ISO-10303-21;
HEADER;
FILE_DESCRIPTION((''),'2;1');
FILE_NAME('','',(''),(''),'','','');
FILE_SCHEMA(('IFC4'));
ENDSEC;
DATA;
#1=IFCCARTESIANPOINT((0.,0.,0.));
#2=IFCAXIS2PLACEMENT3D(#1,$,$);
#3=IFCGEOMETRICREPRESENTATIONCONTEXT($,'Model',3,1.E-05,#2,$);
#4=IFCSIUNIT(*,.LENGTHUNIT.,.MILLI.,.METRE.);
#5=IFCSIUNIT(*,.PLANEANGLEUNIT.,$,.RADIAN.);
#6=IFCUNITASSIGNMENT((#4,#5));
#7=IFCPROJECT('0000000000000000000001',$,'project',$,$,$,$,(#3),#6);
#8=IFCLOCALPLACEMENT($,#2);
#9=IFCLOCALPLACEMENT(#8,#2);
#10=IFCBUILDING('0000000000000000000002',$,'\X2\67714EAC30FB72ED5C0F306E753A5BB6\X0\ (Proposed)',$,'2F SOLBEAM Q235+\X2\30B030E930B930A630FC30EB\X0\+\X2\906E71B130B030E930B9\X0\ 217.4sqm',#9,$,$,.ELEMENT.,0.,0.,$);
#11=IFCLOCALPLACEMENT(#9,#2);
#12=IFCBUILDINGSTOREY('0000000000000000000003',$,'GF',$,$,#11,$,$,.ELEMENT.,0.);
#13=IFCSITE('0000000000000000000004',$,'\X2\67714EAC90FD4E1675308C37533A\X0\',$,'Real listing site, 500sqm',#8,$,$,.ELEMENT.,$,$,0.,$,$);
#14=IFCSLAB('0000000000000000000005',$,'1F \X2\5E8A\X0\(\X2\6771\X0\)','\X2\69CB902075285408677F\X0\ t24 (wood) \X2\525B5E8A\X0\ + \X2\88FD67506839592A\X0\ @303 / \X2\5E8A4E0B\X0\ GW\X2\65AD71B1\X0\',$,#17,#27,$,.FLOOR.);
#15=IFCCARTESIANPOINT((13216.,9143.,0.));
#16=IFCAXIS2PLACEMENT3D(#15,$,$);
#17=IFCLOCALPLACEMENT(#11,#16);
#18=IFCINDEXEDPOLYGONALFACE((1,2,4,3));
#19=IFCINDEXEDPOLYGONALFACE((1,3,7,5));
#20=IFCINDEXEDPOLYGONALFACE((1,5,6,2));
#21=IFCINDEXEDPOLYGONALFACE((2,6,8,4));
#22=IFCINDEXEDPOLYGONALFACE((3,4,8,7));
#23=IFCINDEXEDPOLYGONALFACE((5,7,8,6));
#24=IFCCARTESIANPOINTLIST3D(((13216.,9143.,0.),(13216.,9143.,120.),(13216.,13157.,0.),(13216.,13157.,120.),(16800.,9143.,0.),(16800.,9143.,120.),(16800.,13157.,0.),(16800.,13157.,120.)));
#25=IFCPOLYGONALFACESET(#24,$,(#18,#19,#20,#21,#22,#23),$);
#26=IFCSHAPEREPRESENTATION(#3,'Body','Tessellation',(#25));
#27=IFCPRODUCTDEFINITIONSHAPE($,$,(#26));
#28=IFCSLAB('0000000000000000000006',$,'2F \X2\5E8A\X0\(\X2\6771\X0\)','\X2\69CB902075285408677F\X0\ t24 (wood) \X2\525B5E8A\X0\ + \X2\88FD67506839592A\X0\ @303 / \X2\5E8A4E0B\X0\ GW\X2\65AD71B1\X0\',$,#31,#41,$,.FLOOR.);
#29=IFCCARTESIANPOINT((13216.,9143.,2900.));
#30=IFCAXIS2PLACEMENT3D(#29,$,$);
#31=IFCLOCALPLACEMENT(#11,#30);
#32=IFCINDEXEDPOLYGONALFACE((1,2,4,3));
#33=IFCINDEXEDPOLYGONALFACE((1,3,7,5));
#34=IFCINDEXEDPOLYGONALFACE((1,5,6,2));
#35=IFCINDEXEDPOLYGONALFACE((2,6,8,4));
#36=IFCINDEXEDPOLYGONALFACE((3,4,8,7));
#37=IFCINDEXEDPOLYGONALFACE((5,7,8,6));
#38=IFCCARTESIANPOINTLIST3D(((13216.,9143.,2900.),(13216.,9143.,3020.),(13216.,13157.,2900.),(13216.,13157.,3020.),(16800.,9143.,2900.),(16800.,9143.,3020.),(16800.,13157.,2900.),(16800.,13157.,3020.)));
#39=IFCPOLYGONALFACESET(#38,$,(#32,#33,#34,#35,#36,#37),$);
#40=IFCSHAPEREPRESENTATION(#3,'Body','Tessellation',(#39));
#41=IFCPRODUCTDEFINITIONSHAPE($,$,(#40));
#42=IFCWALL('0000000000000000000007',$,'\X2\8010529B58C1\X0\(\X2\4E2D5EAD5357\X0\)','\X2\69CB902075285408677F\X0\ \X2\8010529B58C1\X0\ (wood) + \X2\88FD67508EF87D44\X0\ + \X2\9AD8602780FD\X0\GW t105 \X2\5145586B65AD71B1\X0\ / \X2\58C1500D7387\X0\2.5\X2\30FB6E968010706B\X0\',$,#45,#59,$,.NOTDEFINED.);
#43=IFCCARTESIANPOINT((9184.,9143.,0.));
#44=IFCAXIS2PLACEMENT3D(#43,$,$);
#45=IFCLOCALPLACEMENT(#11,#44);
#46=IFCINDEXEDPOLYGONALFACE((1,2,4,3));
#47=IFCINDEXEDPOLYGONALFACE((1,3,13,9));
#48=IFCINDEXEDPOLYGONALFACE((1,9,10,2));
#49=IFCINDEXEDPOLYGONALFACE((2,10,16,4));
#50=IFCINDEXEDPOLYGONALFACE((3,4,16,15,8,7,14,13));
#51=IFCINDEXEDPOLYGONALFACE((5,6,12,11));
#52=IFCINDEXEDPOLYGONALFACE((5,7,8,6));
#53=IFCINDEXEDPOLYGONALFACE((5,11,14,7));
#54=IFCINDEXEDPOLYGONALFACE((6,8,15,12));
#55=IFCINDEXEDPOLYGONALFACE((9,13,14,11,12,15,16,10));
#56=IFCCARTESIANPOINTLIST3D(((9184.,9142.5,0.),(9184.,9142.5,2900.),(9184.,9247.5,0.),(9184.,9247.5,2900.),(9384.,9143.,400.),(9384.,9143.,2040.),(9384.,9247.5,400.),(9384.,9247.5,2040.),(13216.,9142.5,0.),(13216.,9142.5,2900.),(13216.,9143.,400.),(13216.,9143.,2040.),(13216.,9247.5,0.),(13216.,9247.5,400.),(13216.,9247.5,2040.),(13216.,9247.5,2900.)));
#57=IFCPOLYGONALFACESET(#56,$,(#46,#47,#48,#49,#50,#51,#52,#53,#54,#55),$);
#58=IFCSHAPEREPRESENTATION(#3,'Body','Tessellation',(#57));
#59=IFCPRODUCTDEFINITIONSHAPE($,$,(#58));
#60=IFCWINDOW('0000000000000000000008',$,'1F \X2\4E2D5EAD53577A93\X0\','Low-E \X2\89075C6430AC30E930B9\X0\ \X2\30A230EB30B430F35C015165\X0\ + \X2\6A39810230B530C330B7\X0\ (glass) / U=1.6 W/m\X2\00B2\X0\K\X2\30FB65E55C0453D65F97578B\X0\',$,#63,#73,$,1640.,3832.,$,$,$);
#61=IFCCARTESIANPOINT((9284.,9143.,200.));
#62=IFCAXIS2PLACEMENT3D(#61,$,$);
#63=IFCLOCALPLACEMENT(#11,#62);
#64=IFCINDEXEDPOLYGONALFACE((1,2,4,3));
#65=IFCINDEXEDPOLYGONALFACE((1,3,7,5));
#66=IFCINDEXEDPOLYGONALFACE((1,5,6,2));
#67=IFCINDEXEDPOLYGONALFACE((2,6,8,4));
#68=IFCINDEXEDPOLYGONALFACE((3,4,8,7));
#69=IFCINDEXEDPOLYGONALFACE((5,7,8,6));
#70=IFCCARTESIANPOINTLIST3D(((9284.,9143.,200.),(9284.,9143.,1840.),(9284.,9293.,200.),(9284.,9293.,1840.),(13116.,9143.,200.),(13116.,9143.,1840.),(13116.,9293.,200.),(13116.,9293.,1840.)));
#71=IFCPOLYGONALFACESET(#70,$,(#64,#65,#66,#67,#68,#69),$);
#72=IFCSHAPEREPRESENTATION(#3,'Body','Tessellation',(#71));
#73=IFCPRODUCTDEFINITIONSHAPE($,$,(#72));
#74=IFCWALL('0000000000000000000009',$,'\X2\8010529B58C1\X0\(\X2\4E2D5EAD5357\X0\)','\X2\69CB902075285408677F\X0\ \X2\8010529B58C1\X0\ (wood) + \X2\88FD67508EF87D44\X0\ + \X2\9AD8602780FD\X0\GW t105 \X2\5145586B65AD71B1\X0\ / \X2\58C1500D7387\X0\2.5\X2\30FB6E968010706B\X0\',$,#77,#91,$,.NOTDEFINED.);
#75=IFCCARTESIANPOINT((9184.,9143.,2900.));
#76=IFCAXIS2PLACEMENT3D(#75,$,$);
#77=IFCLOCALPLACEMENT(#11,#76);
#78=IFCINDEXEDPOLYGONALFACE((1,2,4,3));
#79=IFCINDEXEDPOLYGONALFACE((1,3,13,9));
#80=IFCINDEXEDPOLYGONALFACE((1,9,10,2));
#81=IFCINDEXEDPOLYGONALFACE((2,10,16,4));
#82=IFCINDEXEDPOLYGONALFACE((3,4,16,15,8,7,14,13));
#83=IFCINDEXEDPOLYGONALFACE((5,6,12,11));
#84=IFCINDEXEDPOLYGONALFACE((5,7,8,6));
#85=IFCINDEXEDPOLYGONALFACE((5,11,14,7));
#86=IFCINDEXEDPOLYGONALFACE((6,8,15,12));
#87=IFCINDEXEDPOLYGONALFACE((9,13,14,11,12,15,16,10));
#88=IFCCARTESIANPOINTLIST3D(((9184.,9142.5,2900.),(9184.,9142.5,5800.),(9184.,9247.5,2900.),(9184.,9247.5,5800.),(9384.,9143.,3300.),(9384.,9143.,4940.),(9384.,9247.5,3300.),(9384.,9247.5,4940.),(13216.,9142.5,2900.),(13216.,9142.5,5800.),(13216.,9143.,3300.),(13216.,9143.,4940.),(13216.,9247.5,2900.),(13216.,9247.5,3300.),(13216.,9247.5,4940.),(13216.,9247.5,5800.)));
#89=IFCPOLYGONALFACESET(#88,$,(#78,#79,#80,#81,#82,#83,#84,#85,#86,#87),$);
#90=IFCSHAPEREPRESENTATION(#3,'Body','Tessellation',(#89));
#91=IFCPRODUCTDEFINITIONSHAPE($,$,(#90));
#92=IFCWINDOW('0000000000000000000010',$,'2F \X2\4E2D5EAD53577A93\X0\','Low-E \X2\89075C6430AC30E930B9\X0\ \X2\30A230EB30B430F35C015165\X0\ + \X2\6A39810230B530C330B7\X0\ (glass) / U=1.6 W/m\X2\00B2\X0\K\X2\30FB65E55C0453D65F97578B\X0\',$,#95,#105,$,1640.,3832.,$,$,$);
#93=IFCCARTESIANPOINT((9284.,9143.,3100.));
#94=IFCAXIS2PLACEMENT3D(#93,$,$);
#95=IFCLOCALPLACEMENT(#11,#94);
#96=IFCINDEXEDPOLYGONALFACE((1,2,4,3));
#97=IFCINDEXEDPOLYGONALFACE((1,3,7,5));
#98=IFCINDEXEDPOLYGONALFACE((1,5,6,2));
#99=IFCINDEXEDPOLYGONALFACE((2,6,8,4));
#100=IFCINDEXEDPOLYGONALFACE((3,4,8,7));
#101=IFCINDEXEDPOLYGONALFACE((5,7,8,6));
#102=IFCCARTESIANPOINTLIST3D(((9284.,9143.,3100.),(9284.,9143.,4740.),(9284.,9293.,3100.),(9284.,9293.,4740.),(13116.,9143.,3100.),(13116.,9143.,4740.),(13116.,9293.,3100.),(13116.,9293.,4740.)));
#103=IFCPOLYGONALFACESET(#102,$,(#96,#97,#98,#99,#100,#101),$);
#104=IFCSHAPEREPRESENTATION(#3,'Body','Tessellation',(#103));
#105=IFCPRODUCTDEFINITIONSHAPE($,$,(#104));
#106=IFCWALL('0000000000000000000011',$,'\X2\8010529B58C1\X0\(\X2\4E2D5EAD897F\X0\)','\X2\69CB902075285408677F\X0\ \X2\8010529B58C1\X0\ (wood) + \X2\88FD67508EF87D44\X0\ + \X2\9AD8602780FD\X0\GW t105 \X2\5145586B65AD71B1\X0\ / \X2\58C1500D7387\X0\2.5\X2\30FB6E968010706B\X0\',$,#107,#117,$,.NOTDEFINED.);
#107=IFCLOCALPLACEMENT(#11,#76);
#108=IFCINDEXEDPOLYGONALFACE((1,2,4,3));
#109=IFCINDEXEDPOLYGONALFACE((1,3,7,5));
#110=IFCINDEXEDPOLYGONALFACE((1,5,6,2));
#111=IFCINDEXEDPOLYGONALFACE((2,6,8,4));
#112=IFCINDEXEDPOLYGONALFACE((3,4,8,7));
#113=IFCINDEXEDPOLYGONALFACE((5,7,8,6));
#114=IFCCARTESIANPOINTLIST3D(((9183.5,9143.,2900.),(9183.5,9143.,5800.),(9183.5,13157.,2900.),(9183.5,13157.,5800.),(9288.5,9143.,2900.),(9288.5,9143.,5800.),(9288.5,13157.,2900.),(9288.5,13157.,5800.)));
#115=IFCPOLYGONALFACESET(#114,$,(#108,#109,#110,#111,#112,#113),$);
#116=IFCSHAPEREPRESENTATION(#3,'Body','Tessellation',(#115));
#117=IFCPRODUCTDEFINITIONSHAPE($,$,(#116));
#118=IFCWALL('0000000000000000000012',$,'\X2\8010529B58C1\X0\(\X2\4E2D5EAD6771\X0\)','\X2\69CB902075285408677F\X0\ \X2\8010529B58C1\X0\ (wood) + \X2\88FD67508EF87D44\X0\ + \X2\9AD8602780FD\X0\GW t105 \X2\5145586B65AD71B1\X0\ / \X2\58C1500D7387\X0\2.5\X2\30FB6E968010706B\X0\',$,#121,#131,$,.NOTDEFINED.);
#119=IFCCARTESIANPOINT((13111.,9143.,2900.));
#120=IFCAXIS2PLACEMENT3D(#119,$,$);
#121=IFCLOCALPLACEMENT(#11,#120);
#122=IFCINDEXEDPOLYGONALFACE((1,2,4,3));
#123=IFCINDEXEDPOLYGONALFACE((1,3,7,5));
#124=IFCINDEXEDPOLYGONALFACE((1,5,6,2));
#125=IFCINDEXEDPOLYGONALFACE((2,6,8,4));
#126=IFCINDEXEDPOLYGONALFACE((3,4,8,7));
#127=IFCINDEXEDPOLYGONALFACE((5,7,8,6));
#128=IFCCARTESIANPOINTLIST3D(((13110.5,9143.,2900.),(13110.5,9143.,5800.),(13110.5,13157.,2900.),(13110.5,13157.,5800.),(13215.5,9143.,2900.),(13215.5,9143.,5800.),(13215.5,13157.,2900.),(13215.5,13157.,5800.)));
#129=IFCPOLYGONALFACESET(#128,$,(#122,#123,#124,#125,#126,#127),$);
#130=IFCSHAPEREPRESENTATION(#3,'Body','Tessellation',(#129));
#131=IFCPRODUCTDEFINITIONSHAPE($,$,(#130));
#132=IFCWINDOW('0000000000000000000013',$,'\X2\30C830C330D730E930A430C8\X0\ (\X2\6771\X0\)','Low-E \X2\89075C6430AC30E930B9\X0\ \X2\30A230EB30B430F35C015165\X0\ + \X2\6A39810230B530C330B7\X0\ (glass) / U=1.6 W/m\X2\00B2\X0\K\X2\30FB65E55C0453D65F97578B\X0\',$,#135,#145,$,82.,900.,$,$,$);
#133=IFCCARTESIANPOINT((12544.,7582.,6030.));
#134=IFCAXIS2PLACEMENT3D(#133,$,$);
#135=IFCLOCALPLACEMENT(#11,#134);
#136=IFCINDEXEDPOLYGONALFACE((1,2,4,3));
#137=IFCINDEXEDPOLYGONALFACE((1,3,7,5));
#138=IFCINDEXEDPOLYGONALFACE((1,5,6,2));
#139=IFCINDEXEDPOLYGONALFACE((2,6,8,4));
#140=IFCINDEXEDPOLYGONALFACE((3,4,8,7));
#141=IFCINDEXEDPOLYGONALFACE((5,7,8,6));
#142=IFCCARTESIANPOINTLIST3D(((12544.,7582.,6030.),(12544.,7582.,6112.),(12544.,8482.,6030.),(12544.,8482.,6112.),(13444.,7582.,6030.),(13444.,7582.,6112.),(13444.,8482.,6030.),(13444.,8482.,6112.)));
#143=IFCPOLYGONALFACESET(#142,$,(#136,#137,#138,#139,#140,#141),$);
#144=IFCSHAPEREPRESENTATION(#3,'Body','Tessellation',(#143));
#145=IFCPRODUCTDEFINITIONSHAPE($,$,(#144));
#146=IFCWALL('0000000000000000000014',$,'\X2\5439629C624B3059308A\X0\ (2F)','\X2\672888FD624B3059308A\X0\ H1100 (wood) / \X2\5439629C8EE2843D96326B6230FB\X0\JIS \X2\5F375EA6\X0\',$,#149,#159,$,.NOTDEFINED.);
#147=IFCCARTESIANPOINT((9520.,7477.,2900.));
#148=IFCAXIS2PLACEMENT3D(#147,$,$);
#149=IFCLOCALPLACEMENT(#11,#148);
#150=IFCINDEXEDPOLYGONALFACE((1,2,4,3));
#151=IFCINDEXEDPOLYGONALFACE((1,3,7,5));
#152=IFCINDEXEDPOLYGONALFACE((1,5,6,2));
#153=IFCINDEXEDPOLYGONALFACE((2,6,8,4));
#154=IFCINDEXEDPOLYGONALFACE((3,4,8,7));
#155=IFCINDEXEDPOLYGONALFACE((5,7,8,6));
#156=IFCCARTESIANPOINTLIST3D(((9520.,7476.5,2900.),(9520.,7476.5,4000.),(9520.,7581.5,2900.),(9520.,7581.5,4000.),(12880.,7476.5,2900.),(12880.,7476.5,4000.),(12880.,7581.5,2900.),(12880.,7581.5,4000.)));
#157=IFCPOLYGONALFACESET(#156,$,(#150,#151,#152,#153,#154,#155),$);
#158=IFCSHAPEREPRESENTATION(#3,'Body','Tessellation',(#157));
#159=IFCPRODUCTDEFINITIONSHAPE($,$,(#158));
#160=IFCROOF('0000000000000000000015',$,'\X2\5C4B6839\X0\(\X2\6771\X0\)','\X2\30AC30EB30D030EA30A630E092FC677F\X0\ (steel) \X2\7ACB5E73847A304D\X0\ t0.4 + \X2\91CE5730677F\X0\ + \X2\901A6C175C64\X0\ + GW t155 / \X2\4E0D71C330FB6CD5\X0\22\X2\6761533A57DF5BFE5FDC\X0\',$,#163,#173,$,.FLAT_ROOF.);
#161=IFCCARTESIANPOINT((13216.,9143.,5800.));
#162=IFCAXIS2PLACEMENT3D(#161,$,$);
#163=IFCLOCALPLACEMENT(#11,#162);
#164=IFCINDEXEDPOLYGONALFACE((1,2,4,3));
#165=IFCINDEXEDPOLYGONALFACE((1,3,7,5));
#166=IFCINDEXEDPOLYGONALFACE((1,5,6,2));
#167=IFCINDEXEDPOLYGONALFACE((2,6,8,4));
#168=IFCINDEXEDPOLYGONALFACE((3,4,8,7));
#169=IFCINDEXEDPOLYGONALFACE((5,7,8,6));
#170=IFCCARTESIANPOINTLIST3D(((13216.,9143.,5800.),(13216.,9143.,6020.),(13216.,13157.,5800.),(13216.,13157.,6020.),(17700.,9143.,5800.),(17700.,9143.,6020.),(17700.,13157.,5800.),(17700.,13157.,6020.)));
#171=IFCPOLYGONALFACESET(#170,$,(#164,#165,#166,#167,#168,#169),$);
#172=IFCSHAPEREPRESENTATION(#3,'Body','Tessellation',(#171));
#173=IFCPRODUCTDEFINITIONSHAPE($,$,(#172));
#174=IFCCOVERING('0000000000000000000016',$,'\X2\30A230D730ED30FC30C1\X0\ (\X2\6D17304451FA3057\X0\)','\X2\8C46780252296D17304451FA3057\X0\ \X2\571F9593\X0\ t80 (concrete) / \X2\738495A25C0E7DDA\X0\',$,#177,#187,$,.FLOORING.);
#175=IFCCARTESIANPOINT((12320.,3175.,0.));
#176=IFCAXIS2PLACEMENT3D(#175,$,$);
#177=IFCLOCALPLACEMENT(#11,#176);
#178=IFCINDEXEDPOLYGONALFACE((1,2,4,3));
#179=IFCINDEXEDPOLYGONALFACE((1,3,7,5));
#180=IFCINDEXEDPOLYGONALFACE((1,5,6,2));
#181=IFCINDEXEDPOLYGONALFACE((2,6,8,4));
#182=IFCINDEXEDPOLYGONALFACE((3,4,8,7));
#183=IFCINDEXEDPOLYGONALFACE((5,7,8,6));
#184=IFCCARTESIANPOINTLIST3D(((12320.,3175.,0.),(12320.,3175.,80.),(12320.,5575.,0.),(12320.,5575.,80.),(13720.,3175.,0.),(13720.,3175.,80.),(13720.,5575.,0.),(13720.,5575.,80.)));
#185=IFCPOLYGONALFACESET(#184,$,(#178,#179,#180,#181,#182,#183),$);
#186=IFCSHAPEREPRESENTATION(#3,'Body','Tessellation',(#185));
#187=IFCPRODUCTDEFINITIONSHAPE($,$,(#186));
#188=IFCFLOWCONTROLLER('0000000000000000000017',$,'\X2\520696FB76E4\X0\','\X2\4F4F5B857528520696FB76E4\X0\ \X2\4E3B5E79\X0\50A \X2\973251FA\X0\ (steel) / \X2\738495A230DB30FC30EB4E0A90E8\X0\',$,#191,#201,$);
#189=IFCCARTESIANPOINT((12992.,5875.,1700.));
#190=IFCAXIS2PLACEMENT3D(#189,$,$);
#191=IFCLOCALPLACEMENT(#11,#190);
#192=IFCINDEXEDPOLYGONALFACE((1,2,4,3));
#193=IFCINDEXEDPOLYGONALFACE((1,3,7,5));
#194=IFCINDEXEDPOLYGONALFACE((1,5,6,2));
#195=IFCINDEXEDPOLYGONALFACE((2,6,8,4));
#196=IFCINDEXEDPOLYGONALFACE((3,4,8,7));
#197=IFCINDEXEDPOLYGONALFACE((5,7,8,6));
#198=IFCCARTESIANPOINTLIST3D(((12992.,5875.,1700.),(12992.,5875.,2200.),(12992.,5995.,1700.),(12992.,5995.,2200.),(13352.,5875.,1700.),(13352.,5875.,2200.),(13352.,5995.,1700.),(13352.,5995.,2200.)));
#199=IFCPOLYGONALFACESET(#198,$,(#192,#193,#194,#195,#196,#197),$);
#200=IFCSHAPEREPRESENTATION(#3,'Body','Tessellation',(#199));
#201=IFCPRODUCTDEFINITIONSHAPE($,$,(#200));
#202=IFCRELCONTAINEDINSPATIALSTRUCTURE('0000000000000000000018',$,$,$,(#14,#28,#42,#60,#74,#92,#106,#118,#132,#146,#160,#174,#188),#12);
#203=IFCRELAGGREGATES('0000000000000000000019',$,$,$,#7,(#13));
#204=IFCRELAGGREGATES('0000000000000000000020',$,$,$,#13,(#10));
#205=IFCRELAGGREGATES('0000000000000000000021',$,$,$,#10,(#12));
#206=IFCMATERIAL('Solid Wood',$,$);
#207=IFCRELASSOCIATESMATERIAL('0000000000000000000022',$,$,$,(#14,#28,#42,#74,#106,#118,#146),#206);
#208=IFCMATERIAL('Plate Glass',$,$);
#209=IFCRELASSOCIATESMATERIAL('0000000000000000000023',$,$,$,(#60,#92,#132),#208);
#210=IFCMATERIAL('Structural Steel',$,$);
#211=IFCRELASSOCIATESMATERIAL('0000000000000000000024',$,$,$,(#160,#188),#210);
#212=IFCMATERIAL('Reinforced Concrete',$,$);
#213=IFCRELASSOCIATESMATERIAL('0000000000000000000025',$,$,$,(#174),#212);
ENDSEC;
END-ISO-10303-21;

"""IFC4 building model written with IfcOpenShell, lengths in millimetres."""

from ifc_helpers import new_model, si_unit, frame, frame_2d, origin, place, context, project, spatial, rectangle, extrude, material, element, fill, save


model = new_model("IFC4")

# Units and contexts
model_context = context("Model", 3, precision=1e-05, world=origin())
ifc_project = project(units=[si_unit("LENGTHUNIT", "METRE", prefix="MILLI"), si_unit("PLANEANGLEUNIT", "RADIAN")], contexts=[model_context])

# Site, building, storey
site_placement = place(None, origin())
site = spatial("IfcSite", under=ifc_project, at=site_placement, Name="東京都世田谷区", ObjectType="Real listing site, 500sqm", CompositionType="ELEMENT", RefElevation=0.0)
building_placement = place(site_placement, origin())
building = spatial("IfcBuilding", under=site, at=building_placement, Name="東京・狭小の町家 (Proposed)", ObjectType="2F SOLBEAM Q235+グラスウール+遮熱グラス 217.4sqm", CompositionType="ELEMENT", ElevationOfRefHeight=0.0, ElevationOfTerrain=0.0)
storey_placement = place(building_placement, origin())
storey = spatial("IfcBuildingStorey", under=building, at=storey_placement, Name="GF", CompositionType="ELEMENT", Elevation=0.0)

# Shared definitions
ifc_material_1 = material(Name="Solid Wood")

# Slabs
slab_1_placement = place(storey_placement, frame((13216.0, 9143.0, 0.0)))
element("IfcSlab", 1, at=slab_1_placement, inside=storey, material=ifc_material_1, Name="1F 床(東)", Description="構造用合板 t24 (wood) 剛床 + 製材根太 @303 / 床下 GW断熱", PredefinedType="FLOOR", context=model_context, shape_type="SweptSolid", body=[
    extrude(rectangle(XDim=3584.0, YDim=4014.0, at=frame_2d((1792.0, 2007.0))), frame((13216.0, 9143.0, 0.0)), (0.0, 0.0, 1.0), 120.0),
])
slab_2_placement = place(storey_placement, frame((13216.0, 9143.0, 2900.0)))
element("IfcSlab", 2, at=slab_2_placement, inside=storey, material=ifc_material_1, Name="2F 床(東)", Description="構造用合板 t24 (wood) 剛床 + 製材根太 @303 / 床下 GW断熱", PredefinedType="FLOOR", context=model_context, shape_type="SweptSolid", body=[
    extrude(rectangle(XDim=3584.0, YDim=4014.0, at=frame_2d((1792.0, 2007.0))), frame((13216.0, 9143.0, 2900.0)), (0.0, 0.0, 1.0), 120.0),
])

# Wall, opening, window
wall_1_placement = place(storey_placement, frame((9184.0, 9143.0, 0.0)))
wall_1 = element("IfcWall", 3, at=wall_1_placement, inside=storey, material=ifc_material_1, Name="耐力壁(中庭南)", Description="構造用合板 耐力壁 (wood) + 製材軸組 + 高性能GW t105 充填断熱 / 壁倍率2.5・準耐火", PredefinedType="NOTDEFINED", context=model_context, shape_type="SweptSolid", body=[
    extrude(rectangle(XDim=4032.0, YDim=105.0, at=frame_2d((2016.0, 52.0))), frame((9184.0, 9143.0, 0.0)), (0.0, 0.0, 1.0), 2900.0),
])
opening_1_placement = place(storey_placement, frame((9284.0, 9143.0, 200.0)))
opening_1 = element("IfcOpeningElement", 4, at=opening_1_placement, cuts=wall_1, PredefinedType="NOTDEFINED", context=model_context, shape_type="SweptSolid", body=[
    extrude(rectangle(XDim=3832.0, YDim=150.0, at=frame_2d((1916.0, 75.0))), frame((9284.0, 9143.0, 200.0)), (0.0, 0.0, 1.0), 1640.0),
])
ifc_material_2 = material(Name="Plate Glass")
window_1_placement = place(storey_placement, frame((9284.0, 9143.0, 200.0)))
window_1 = element("IfcWindow", 5, at=window_1_placement, inside=storey, material=ifc_material_2, Name="1F 中庭南窓", Description="Low-E 複層ガラス アルゴン封入 + 樹脂サッシ (glass) / U=1.6 W/m²K・日射取得型", OverallHeight=1640.0, OverallWidth=3832.0, context=model_context, shape_type="SweptSolid", body=[
    extrude(rectangle(XDim=3832.0, YDim=150.0, at=frame_2d((1916.0, 75.0))), frame((9284.0, 9143.0, 200.0)), (0.0, 0.0, 1.0), 1640.0),
])
fill(opening_1, window_1)

# Wall, opening, window
wall_2_placement = place(storey_placement, frame((9184.0, 9143.0, 2900.0)))
wall_2 = element("IfcWall", 6, at=wall_2_placement, inside=storey, material=ifc_material_1, Name="耐力壁(中庭南)", Description="構造用合板 耐力壁 (wood) + 製材軸組 + 高性能GW t105 充填断熱 / 壁倍率2.5・準耐火", PredefinedType="NOTDEFINED", context=model_context, shape_type="SweptSolid", body=[
    extrude(rectangle(XDim=4032.0, YDim=105.0, at=frame_2d((2016.0, 52.0))), frame((9184.0, 9143.0, 2900.0)), (0.0, 0.0, 1.0), 2900.0),
])
opening_2_placement = place(storey_placement, frame((9284.0, 9143.0, 3100.0)))
opening_2 = element("IfcOpeningElement", 7, at=opening_2_placement, cuts=wall_2, PredefinedType="NOTDEFINED", context=model_context, shape_type="SweptSolid", body=[
    extrude(rectangle(XDim=3832.0, YDim=150.0, at=frame_2d((1916.0, 75.0))), frame((9284.0, 9143.0, 3100.0)), (0.0, 0.0, 1.0), 1640.0),
])
window_2_placement = place(storey_placement, frame((9284.0, 9143.0, 3100.0)))
window_2 = element("IfcWindow", 8, at=window_2_placement, inside=storey, material=ifc_material_2, Name="2F 中庭南窓", Description="Low-E 複層ガラス アルゴン封入 + 樹脂サッシ (glass) / U=1.6 W/m²K・日射取得型", OverallHeight=1640.0, OverallWidth=3832.0, context=model_context, shape_type="SweptSolid", body=[
    extrude(rectangle(XDim=3832.0, YDim=150.0, at=frame_2d((1916.0, 75.0))), frame((9284.0, 9143.0, 3100.0)), (0.0, 0.0, 1.0), 1640.0),
])
fill(opening_2, window_2)

# Walls
wall_3_placement = place(storey_placement, frame((9184.0, 9143.0, 2900.0)))
element("IfcWall", 9, at=wall_3_placement, inside=storey, material=ifc_material_1, Name="耐力壁(中庭西)", Description="構造用合板 耐力壁 (wood) + 製材軸組 + 高性能GW t105 充填断熱 / 壁倍率2.5・準耐火", PredefinedType="NOTDEFINED", context=model_context, shape_type="SweptSolid", body=[
    extrude(rectangle(XDim=105.0, YDim=4014.0, at=frame_2d((52.0, 2007.0))), frame((9184.0, 9143.0, 2900.0)), (0.0, 0.0, 1.0), 2900.0),
])
wall_4_placement = place(storey_placement, frame((13111.0, 9143.0, 2900.0)))
element("IfcWall", 10, at=wall_4_placement, inside=storey, material=ifc_material_1, Name="耐力壁(中庭東)", Description="構造用合板 耐力壁 (wood) + 製材軸組 + 高性能GW t105 充填断熱 / 壁倍率2.5・準耐火", PredefinedType="NOTDEFINED", context=model_context, shape_type="SweptSolid", body=[
    extrude(rectangle(XDim=105.0, YDim=4014.0, at=frame_2d((52.0, 2007.0))), frame((13111.0, 9143.0, 2900.0)), (0.0, 0.0, 1.0), 2900.0),
])

# Window
window_3_placement = place(storey_placement, frame((12544.0, 7582.0, 6030.0)))
element("IfcWindow", 11, at=window_3_placement, inside=storey, material=ifc_material_2, Name="トップライト (東)", Description="Low-E 複層ガラス アルゴン封入 + 樹脂サッシ (glass) / U=1.6 W/m²K・日射取得型", OverallHeight=82.0, OverallWidth=900.0, context=model_context, shape_type="SweptSolid", body=[
    extrude(rectangle(XDim=900.0, YDim=900.0, at=frame_2d((450.0, 450.0))), frame((12544.0, 7582.0, 6030.0)), (0.0, 0.0, 1.0), 82.0),
])

# Wall
wall_5_placement = place(storey_placement, frame((9520.0, 7477.0, 2900.0)))
element("IfcWall", 12, at=wall_5_placement, inside=storey, material=ifc_material_1, Name="吹抜手すり (2F)", Description="木製手すり H1100 (wood) / 吹抜転落防止・JIS 強度", PredefinedType="NOTDEFINED", context=model_context, shape_type="SweptSolid", body=[
    extrude(rectangle(XDim=3360.0, YDim=105.0, at=frame_2d((1680.0, 52.0))), frame((9520.0, 7477.0, 2900.0)), (0.0, 0.0, 1.0), 1100.0),
])

# Roof
ifc_material_3 = material(Name="Structural Steel")
for number, where, name in (
    (13, (13216.0, 9143.0, 5800.0), "屋根(東)"),
):
    element("IfcRoof", number, at=place(storey_placement, frame(where)), inside=storey, material=ifc_material_3, Name=name, Description="ガルバリウム鋼板 (steel) 立平葺き t0.4 + 野地板 + 通気層 + GW t155 / 不燃・法22条区域対応", PredefinedType="FLAT_ROOF", context=model_context, shape_type="SweptSolid", body=[
        extrude(rectangle(XDim=4484.0, YDim=4014.0, at=frame_2d((2242.0, 2007.0))), frame((13216.0, 9143.0, 5800.0)), (0.0, 0.0, 1.0), 220.0),
    ])

# Covering
ifc_material_4 = material(Name="Reinforced Concrete")
covering_placement = place(storey_placement, frame((12320.0, 3175.0, 0.0)))
element("IfcCovering", 14, at=covering_placement, inside=storey, material=ifc_material_4, Name="アプローチ (洗い出し)", Description="豆砂利洗い出し 土間 t80 (concrete) / 玄関導線", PredefinedType="FLOORING", context=model_context, shape_type="SweptSolid", body=[
    extrude(rectangle(XDim=1400.0, YDim=2400.0, at=frame_2d((700.0, 1200.0))), frame((12320.0, 3175.0, 0.0)), (0.0, 0.0, 1.0), 80.0),
])

# Flow controller
flow_controller_placement = place(storey_placement, frame((12992.0, 5875.0, 1700.0)))
element("IfcFlowController", 15, at=flow_controller_placement, inside=storey, material=ifc_material_3, Name="分電盤", Description="住宅用分電盤 主幹50A 露出 (steel) / 玄関ホール上部", context=model_context, shape_type="SweptSolid", body=[
    extrude(rectangle(XDim=360.0, YDim=120.0, at=frame_2d((180.0, 60.0))), frame((12992.0, 5875.0, 1700.0)), (0.0, 0.0, 1.0), 500.0),
])

save(model, "model.ifc")
